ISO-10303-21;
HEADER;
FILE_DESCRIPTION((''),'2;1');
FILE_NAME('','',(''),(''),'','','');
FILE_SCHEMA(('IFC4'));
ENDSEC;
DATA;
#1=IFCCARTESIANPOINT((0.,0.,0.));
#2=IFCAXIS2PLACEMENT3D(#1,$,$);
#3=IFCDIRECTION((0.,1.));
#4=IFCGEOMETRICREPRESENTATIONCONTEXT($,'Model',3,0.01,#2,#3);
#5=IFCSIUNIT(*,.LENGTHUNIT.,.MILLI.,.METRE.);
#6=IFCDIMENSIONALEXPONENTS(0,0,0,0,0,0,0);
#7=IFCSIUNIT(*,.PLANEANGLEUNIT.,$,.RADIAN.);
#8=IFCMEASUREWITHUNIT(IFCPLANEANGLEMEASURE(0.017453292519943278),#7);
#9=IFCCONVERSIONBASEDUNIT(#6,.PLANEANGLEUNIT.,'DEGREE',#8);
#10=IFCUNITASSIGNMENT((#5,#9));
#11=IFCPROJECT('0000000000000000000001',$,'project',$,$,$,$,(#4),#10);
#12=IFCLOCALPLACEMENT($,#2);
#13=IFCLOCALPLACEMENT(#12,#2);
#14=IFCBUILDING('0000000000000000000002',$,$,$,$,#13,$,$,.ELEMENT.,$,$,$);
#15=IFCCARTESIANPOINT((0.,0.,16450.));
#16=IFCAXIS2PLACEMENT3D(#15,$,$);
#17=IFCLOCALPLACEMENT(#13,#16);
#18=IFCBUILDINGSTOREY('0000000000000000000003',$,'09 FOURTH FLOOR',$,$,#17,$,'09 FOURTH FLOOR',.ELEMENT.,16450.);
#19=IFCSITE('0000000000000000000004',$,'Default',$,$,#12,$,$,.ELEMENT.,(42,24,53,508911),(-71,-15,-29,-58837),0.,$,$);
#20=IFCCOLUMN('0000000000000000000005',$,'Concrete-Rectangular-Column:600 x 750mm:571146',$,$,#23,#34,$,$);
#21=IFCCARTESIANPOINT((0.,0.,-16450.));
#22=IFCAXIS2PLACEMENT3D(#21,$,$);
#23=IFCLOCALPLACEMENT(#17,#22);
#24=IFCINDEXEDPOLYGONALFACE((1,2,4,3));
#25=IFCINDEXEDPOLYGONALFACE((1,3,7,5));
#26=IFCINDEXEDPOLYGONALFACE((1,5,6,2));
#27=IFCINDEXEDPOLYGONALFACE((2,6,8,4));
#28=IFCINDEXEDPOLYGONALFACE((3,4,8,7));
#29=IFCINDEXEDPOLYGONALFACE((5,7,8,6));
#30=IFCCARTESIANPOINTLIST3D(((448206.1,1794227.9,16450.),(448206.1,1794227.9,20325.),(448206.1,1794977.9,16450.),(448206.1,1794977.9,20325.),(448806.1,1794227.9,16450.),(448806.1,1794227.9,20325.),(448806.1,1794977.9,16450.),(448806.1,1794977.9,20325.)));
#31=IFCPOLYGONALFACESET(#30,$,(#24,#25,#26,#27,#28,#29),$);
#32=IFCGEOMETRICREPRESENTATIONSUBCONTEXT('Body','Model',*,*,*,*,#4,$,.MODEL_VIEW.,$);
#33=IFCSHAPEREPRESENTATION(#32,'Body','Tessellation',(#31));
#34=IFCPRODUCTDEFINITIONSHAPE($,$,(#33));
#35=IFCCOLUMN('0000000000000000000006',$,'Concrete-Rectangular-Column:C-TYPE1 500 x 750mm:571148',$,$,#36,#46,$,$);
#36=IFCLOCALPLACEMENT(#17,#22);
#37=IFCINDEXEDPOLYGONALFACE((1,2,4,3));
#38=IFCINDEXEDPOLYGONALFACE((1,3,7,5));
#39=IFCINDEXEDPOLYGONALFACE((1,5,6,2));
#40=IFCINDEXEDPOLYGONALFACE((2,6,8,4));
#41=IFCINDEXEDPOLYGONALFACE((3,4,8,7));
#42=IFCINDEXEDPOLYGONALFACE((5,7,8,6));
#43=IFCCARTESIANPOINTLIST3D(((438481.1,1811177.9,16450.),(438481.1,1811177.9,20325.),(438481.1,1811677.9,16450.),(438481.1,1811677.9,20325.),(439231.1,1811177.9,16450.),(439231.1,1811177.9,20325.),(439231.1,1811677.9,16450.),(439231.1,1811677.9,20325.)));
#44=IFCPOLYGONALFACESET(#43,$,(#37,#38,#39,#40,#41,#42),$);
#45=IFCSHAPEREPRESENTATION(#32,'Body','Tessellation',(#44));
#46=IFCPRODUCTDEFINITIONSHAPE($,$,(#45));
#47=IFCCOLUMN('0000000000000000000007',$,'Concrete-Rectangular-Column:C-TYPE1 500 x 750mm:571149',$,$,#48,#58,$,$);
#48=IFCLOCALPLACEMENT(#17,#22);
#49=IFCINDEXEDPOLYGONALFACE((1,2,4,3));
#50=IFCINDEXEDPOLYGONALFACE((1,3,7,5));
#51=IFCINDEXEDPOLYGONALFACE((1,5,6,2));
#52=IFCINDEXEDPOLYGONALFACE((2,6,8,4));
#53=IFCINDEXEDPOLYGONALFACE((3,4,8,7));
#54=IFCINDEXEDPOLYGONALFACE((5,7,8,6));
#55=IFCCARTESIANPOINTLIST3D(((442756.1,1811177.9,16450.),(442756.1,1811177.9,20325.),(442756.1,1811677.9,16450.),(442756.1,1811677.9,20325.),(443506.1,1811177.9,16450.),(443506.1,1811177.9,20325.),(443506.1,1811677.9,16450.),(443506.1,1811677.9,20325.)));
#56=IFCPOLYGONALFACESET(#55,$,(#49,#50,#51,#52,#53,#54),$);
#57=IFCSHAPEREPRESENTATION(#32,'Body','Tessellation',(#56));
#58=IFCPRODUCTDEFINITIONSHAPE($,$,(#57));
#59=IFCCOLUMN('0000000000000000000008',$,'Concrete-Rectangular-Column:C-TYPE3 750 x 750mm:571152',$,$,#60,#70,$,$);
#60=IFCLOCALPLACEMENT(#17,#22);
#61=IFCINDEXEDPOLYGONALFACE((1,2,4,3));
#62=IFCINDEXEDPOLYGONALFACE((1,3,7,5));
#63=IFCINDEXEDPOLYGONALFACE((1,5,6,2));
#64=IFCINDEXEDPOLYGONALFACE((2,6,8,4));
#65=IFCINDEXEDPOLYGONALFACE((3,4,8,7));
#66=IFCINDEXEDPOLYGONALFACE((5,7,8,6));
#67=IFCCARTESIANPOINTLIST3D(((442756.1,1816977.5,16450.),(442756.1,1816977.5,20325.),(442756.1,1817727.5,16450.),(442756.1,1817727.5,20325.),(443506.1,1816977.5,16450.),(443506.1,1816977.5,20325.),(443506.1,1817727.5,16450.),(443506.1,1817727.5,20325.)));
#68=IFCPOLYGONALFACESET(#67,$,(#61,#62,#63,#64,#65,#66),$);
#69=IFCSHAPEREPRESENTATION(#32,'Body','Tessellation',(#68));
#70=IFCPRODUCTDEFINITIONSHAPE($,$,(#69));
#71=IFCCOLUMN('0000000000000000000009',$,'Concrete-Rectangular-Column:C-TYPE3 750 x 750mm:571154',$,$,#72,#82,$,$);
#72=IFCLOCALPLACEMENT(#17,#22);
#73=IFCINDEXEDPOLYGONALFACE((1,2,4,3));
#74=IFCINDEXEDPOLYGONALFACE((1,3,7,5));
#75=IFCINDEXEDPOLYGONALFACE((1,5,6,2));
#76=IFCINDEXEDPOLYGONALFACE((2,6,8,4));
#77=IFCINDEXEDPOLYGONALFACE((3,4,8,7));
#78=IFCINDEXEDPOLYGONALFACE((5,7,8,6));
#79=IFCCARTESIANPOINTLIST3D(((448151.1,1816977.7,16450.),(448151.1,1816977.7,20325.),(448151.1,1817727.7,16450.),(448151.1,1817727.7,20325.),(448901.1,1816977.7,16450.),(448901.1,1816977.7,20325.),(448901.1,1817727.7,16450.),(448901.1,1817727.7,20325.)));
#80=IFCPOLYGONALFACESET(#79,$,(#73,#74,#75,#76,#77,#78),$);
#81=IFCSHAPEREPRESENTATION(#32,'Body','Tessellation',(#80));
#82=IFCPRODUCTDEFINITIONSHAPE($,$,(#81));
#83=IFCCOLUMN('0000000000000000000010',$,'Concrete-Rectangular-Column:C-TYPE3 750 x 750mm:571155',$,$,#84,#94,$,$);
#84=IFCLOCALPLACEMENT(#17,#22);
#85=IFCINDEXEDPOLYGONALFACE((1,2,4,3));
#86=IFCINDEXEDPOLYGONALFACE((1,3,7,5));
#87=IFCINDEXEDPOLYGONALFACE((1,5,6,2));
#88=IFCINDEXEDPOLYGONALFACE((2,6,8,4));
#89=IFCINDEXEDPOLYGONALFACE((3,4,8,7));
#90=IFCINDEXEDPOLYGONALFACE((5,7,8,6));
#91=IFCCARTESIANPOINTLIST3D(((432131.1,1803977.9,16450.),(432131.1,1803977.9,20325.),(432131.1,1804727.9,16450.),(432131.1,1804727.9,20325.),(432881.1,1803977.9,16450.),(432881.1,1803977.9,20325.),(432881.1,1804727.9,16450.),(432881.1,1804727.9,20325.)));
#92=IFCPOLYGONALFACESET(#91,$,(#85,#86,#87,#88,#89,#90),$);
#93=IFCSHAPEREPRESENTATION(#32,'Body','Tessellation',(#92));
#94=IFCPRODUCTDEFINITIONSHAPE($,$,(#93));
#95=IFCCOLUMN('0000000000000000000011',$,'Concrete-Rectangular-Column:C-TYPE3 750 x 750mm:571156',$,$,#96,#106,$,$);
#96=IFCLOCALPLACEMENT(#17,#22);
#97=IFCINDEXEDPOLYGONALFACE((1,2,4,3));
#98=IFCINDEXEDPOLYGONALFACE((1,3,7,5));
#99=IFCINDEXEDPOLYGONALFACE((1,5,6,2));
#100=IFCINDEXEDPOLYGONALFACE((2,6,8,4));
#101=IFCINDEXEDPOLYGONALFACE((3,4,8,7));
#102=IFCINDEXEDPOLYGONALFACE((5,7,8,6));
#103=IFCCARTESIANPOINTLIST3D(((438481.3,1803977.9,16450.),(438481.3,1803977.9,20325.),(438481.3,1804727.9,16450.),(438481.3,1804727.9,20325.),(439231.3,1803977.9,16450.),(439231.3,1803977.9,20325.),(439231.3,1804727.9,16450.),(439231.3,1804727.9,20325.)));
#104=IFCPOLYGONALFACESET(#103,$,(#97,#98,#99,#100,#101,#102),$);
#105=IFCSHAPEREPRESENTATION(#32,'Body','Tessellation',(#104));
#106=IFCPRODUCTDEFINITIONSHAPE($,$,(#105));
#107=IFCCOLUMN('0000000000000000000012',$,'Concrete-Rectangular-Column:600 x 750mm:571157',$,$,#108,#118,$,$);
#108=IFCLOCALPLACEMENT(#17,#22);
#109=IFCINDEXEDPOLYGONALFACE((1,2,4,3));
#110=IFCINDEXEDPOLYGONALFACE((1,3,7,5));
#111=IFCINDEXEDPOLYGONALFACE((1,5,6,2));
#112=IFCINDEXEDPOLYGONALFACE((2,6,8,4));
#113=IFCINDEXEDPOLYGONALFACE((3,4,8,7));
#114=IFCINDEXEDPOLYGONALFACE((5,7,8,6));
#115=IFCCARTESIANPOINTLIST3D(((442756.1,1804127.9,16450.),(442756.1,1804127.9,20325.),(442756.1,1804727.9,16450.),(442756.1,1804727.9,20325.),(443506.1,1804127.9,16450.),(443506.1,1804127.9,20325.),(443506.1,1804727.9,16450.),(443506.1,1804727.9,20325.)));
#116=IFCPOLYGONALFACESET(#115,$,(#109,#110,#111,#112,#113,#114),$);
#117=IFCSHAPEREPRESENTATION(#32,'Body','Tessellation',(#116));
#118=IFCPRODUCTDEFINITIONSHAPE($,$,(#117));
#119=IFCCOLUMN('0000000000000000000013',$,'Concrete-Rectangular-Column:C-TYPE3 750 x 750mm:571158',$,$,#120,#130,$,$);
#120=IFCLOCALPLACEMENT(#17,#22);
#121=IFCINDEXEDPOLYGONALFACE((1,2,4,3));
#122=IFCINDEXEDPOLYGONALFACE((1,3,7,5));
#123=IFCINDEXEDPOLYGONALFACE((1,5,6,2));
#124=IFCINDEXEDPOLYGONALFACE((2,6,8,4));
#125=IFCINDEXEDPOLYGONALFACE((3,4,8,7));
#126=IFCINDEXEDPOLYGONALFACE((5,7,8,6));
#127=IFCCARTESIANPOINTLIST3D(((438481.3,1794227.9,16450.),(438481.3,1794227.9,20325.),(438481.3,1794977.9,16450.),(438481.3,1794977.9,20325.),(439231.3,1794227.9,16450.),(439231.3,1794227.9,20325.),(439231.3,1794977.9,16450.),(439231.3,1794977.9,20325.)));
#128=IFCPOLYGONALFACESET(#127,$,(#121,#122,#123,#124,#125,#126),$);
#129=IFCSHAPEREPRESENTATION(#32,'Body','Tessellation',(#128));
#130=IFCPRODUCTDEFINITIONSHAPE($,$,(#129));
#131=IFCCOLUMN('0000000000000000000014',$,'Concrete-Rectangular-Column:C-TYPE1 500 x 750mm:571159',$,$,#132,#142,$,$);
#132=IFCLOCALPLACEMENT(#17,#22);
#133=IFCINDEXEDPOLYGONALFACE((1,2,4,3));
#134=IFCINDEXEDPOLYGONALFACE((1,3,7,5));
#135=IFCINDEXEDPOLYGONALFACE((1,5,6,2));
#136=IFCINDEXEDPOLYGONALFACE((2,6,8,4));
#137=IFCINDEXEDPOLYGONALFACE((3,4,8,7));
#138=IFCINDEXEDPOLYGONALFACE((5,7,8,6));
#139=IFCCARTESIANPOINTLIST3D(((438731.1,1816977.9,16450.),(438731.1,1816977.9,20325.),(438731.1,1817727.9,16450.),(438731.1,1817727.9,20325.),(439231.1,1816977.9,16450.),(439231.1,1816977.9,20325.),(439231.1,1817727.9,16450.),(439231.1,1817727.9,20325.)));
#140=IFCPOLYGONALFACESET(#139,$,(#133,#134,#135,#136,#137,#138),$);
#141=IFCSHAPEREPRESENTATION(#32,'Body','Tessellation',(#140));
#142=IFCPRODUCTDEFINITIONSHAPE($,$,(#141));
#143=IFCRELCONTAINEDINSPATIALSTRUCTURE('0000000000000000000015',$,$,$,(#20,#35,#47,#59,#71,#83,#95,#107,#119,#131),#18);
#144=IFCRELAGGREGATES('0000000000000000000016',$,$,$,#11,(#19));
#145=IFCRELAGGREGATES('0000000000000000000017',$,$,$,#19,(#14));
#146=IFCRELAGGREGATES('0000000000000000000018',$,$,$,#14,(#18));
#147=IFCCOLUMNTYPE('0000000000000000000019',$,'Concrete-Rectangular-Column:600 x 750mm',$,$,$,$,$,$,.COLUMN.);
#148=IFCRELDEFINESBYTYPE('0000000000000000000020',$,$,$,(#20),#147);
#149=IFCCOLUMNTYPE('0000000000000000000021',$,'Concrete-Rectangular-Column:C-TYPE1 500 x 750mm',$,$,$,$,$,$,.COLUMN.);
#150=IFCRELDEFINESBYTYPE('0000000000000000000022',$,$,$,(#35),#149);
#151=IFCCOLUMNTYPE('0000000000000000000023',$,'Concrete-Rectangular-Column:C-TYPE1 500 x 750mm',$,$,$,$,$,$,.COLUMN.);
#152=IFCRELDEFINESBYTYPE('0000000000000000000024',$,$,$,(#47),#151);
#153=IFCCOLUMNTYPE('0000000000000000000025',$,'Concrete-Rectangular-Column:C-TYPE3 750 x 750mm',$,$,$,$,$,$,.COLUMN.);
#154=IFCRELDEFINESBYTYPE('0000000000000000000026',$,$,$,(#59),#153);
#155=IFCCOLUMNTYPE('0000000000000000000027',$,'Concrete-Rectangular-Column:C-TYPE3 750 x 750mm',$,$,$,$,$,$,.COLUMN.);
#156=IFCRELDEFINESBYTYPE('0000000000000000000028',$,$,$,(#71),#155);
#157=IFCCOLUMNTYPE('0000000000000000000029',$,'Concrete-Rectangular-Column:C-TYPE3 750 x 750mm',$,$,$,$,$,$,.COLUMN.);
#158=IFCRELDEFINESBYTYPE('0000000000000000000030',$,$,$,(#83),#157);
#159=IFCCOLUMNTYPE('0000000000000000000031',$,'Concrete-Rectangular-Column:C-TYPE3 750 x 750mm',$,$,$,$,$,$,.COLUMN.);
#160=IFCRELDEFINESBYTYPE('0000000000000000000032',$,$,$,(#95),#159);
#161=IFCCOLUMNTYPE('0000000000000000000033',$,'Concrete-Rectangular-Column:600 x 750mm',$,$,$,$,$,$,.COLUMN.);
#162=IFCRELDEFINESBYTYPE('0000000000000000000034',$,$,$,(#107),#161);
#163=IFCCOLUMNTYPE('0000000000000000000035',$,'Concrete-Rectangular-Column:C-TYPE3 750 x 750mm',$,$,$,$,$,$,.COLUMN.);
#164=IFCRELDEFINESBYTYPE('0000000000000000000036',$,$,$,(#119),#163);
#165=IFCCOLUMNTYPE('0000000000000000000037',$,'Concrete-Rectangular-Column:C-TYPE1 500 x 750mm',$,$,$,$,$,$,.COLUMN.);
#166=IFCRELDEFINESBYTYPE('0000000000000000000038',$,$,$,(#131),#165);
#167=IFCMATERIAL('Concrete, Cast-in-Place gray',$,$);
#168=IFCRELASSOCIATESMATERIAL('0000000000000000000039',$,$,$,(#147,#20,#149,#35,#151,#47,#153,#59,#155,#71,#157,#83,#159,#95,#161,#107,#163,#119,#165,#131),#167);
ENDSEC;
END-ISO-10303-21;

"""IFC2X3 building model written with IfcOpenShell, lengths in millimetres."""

from ifc_helpers import new_model, entity, si_unit, converted_unit, direction, frame, frame_2d, origin, place, context, subcontext, project, spatial, rectangle, extrude, source, transform, mapped, material, type_object, type_shapes, element, save


model = new_model("IFC2X3")

# Units and contexts
model_context = context("Model", 3, precision=0.01, world=origin(), true_north=direction((0.0, 1.0)))
body_context = subcontext(model_context, "Body", "Model", "MODEL_VIEW")
ifc_project = project(units=[si_unit("LENGTHUNIT", "METRE", prefix="MILLI"), converted_unit("PLANEANGLEUNIT", "DEGREE", entity("IfcPlaneAngleMeasure", 0.017453292519943278), si_unit("PLANEANGLEUNIT", "RADIAN"), dimensions=[0, 0, 0, 0, 0, 0, 0])], contexts=[model_context])

# Site, building, storey
site_placement = place(None, origin())
site = spatial("IfcSite", under=ifc_project, at=site_placement, Name="Default", CompositionType="ELEMENT", RefLatitude=(42, 24, 53, 508911), RefLongitude=(-71, -15, -29, -58837), RefElevation=0.0)
building_placement = place(site_placement, origin())
building = spatial("IfcBuilding", under=site, at=building_placement, CompositionType="ELEMENT")
storey_placement = place(building_placement, frame((0.0, 0.0, 16450.0)))
storey = spatial("IfcBuildingStorey", under=building, at=storey_placement, Name="09 FOURTH FLOOR", LongName="09 FOURTH FLOOR", CompositionType="ELEMENT", Elevation=16450.0)

# Columns
ifc_material = material(Name="Concrete, Cast-in-Place gray")
column_type_1 = type_object("IfcColumnType", Name="Concrete-Rectangular-Column:600 x 750mm", PredefinedType="COLUMN", material=ifc_material)
shared_shape_1 = source(origin(), body_context, "Body", "SweptSolid", [
    extrude(rectangle(XDim=3875.0, YDim=750.0, at=frame_2d((0.0, 0.0), x_axis=(1.0, 0.0))), frame((448206.1, 1794602.9, 18387.5), z_axis=(1.0, 0.0, 0.0), x_axis=(0.0, 0.0, 1.0)), (0.0, 0.0, 1.0), 600.0),
])
type_shapes(column_type_1, [shared_shape_1])
column_1_placement = place(storey_placement, frame((0.0, 0.0, -16450.0)))
element("IfcColumn", 1, at=column_1_placement, inside=storey, type_object=column_type_1, material=ifc_material, Name="Concrete-Rectangular-Column:600 x 750mm:571146", context=body_context, shape_type="MappedRepresentation", body=[
    mapped(shared_shape_1, transform((0.0, 0.0, 0.0), scale=1.0)),
])
column_type_2 = type_object("IfcColumnType", Name="Concrete-Rectangular-Column:C-TYPE1 500 x 750mm", PredefinedType="COLUMN", material=ifc_material)
shared_shape_2 = source(origin(), body_context, "Body", "SweptSolid", [
    extrude(rectangle(XDim=500.0, YDim=750.0, at=frame_2d((0.0, 0.0), x_axis=(1.0, 0.0))), frame((438856.1, 1811427.9, 16450.0), z_axis=(0.0, 0.0, 1.0), x_axis=(0.0, -1.0, 0.0)), (0.0, 0.0, 1.0), 3875.0),
])
type_shapes(column_type_2, [shared_shape_2])
column_2_placement = place(storey_placement, frame((0.0, 0.0, -16450.0)))
element("IfcColumn", 2, at=column_2_placement, inside=storey, type_object=column_type_2, material=ifc_material, Name="Concrete-Rectangular-Column:C-TYPE1 500 x 750mm:571148", context=body_context, shape_type="MappedRepresentation", body=[
    mapped(shared_shape_2, transform((0.0, 0.0, 0.0), scale=1.0)),
])
column_type_3 = type_object("IfcColumnType", Name="Concrete-Rectangular-Column:C-TYPE1 500 x 750mm", PredefinedType="COLUMN", material=ifc_material)
shared_shape_3 = source(origin(), body_context, "Body", "SweptSolid", [
    extrude(rectangle(XDim=500.0, YDim=750.0, at=frame_2d((0.0, 0.0), x_axis=(1.0, 0.0))), frame((443131.1, 1811427.9, 16450.0), z_axis=(0.0, 0.0, 1.0), x_axis=(0.0, -1.0, 0.0)), (0.0, 0.0, 1.0), 3875.0),
])
type_shapes(column_type_3, [shared_shape_3])
column_3_placement = place(storey_placement, frame((0.0, 0.0, -16450.0)))
element("IfcColumn", 3, at=column_3_placement, inside=storey, type_object=column_type_3, material=ifc_material, Name="Concrete-Rectangular-Column:C-TYPE1 500 x 750mm:571149", context=body_context, shape_type="MappedRepresentation", body=[
    mapped(shared_shape_3, transform((0.0, 0.0, 0.0), scale=1.0)),
])
column_type_4 = type_object("IfcColumnType", Name="Concrete-Rectangular-Column:C-TYPE3 750 x 750mm", PredefinedType="COLUMN", material=ifc_material)
shared_shape_4 = source(origin(), body_context, "Body", "SweptSolid", [
    extrude(rectangle(XDim=750.0, YDim=750.0, at=frame_2d((0.0, 0.0), x_axis=(1.0, 0.0))), frame((443131.1, 1817352.5, 16450.0), z_axis=(0.0, 0.0, 1.0), x_axis=(0.0, -1.0, 0.0)), (0.0, 0.0, 1.0), 3875.0),
])
type_shapes(column_type_4, [shared_shape_4])
column_4_placement = place(storey_placement, frame((0.0, 0.0, -16450.0)))
element("IfcColumn", 4, at=column_4_placement, inside=storey, type_object=column_type_4, material=ifc_material, Name="Concrete-Rectangular-Column:C-TYPE3 750 x 750mm:571152", context=body_context, shape_type="MappedRepresentation", body=[
    mapped(shared_shape_4, transform((0.0, 0.0, 0.0), scale=1.0)),
])
column_type_5 = type_object("IfcColumnType", Name="Concrete-Rectangular-Column:C-TYPE3 750 x 750mm", PredefinedType="COLUMN", material=ifc_material)
shared_shape_5 = source(origin(), body_context, "Body", "SweptSolid", [
    extrude(rectangle(XDim=750.0, YDim=750.0, at=frame_2d((0.0, 0.0), x_axis=(1.0, 0.0))), frame((448526.1, 1817352.7, 16450.0), z_axis=(0.0, 0.0, 1.0), x_axis=(0.0, -1.0, 0.0)), (0.0, 0.0, 1.0), 3875.0),
])
type_shapes(column_type_5, [shared_shape_5])
column_5_placement = place(storey_placement, frame((0.0, 0.0, -16450.0)))
element("IfcColumn", 5, at=column_5_placement, inside=storey, type_object=column_type_5, material=ifc_material, Name="Concrete-Rectangular-Column:C-TYPE3 750 x 750mm:571154", context=body_context, shape_type="MappedRepresentation", body=[
    mapped(shared_shape_5, transform((0.0, 0.0, 0.0), scale=1.0)),
])
column_type_6 = type_object("IfcColumnType", Name="Concrete-Rectangular-Column:C-TYPE3 750 x 750mm", PredefinedType="COLUMN", material=ifc_material)
shared_shape_6 = source(origin(), body_context, "Body", "SweptSolid", [
    extrude(rectangle(XDim=750.0, YDim=750.0, at=frame_2d((0.0, 0.0), x_axis=(1.0, 0.0))), frame((432506.1, 1804352.9, 16450.0), z_axis=(0.0, 0.0, 1.0), x_axis=(0.0, -1.0, 0.0)), (0.0, 0.0, 1.0), 3875.0),
])
type_shapes(column_type_6, [shared_shape_6])
column_6_placement = place(storey_placement, frame((0.0, 0.0, -16450.0)))
element("IfcColumn", 6, at=column_6_placement, inside=storey, type_object=column_type_6, material=ifc_material, Name="Concrete-Rectangular-Column:C-TYPE3 750 x 750mm:571155", context=body_context, shape_type="MappedRepresentation", body=[
    mapped(shared_shape_6, transform((0.0, 0.0, 0.0), scale=1.0)),
])
column_type_7 = type_object("IfcColumnType", Name="Concrete-Rectangular-Column:C-TYPE3 750 x 750mm", PredefinedType="COLUMN", material=ifc_material)
shared_shape_7 = source(origin(), body_context, "Body", "SweptSolid", [
    extrude(rectangle(XDim=750.0, YDim=750.0, at=frame_2d((0.0, 0.0), x_axis=(1.0, 0.0))), frame((438856.3, 1804352.9, 16450.0), z_axis=(0.0, 0.0, 1.0), x_axis=(0.0, -1.0, 0.0)), (0.0, 0.0, 1.0), 3875.0),
])
type_shapes(column_type_7, [shared_shape_7])
column_7_placement = place(storey_placement, frame((0.0, 0.0, -16450.0)))
element("IfcColumn", 7, at=column_7_placement, inside=storey, type_object=column_type_7, material=ifc_material, Name="Concrete-Rectangular-Column:C-TYPE3 750 x 750mm:571156", context=body_context, shape_type="MappedRepresentation", body=[
    mapped(shared_shape_7, transform((0.0, 0.0, 0.0), scale=1.0)),
])
column_type_8 = type_object("IfcColumnType", Name="Concrete-Rectangular-Column:600 x 750mm", PredefinedType="COLUMN", material=ifc_material)
shared_shape_8 = source(origin(), body_context, "Body", "SweptSolid", [
    extrude(rectangle(XDim=600.0, YDim=750.0, at=frame_2d((0.0, 0.0), x_axis=(1.0, 0.0))), frame((443131.1, 1804427.9, 16450.0), z_axis=(0.0, 0.0, 1.0), x_axis=(0.0, -1.0, 0.0)), (0.0, 0.0, 1.0), 3875.0),
])
type_shapes(column_type_8, [shared_shape_8])
column_8_placement = place(storey_placement, frame((0.0, 0.0, -16450.0)))
element("IfcColumn", 8, at=column_8_placement, inside=storey, type_object=column_type_8, material=ifc_material, Name="Concrete-Rectangular-Column:600 x 750mm:571157", context=body_context, shape_type="MappedRepresentation", body=[
    mapped(shared_shape_8, transform((0.0, 0.0, 0.0), scale=1.0)),
])
column_type_9 = type_object("IfcColumnType", Name="Concrete-Rectangular-Column:C-TYPE3 750 x 750mm", PredefinedType="COLUMN", material=ifc_material)
shared_shape_9 = source(origin(), body_context, "Body", "SweptSolid", [
    extrude(rectangle(XDim=750.0, YDim=750.0, at=frame_2d((0.0, 0.0), x_axis=(1.0, 0.0))), frame((438856.3, 1794602.9, 16450.0), z_axis=(0.0, 0.0, 1.0), x_axis=(0.0, -1.0, 0.0)), (0.0, 0.0, 1.0), 3875.0),
])
type_shapes(column_type_9, [shared_shape_9])
column_9_placement = place(storey_placement, frame((0.0, 0.0, -16450.0)))
element("IfcColumn", 9, at=column_9_placement, inside=storey, type_object=column_type_9, material=ifc_material, Name="Concrete-Rectangular-Column:C-TYPE3 750 x 750mm:571158", context=body_context, shape_type="MappedRepresentation", body=[
    mapped(shared_shape_9, transform((0.0, 0.0, 0.0), scale=1.0)),
])
column_type_10 = type_object("IfcColumnType", Name="Concrete-Rectangular-Column:C-TYPE1 500 x 750mm", PredefinedType="COLUMN", material=ifc_material)
shared_shape_10 = source(origin(), body_context, "Body", "SweptSolid", [
    extrude(rectangle(XDim=3875.0, YDim=750.0, at=frame_2d((0.0, 0.0), x_axis=(1.0, 0.0))), frame((438731.1, 1817352.9, 18387.5), z_axis=(1.0, 0.0, 0.0), x_axis=(0.0, 0.0, 1.0)), (0.0, 0.0, 1.0), 500.0),
])
type_shapes(column_type_10, [shared_shape_10])
column_10_placement = place(storey_placement, frame((0.0, 0.0, -16450.0)))
element("IfcColumn", 10, at=column_10_placement, inside=storey, type_object=column_type_10, material=ifc_material, Name="Concrete-Rectangular-Column:C-TYPE1 500 x 750mm:571159", context=body_context, shape_type="MappedRepresentation", body=[
    mapped(shared_shape_10, transform((0.0, 0.0, 0.0), scale=1.0)),
])

save(model, "model.ifc")
